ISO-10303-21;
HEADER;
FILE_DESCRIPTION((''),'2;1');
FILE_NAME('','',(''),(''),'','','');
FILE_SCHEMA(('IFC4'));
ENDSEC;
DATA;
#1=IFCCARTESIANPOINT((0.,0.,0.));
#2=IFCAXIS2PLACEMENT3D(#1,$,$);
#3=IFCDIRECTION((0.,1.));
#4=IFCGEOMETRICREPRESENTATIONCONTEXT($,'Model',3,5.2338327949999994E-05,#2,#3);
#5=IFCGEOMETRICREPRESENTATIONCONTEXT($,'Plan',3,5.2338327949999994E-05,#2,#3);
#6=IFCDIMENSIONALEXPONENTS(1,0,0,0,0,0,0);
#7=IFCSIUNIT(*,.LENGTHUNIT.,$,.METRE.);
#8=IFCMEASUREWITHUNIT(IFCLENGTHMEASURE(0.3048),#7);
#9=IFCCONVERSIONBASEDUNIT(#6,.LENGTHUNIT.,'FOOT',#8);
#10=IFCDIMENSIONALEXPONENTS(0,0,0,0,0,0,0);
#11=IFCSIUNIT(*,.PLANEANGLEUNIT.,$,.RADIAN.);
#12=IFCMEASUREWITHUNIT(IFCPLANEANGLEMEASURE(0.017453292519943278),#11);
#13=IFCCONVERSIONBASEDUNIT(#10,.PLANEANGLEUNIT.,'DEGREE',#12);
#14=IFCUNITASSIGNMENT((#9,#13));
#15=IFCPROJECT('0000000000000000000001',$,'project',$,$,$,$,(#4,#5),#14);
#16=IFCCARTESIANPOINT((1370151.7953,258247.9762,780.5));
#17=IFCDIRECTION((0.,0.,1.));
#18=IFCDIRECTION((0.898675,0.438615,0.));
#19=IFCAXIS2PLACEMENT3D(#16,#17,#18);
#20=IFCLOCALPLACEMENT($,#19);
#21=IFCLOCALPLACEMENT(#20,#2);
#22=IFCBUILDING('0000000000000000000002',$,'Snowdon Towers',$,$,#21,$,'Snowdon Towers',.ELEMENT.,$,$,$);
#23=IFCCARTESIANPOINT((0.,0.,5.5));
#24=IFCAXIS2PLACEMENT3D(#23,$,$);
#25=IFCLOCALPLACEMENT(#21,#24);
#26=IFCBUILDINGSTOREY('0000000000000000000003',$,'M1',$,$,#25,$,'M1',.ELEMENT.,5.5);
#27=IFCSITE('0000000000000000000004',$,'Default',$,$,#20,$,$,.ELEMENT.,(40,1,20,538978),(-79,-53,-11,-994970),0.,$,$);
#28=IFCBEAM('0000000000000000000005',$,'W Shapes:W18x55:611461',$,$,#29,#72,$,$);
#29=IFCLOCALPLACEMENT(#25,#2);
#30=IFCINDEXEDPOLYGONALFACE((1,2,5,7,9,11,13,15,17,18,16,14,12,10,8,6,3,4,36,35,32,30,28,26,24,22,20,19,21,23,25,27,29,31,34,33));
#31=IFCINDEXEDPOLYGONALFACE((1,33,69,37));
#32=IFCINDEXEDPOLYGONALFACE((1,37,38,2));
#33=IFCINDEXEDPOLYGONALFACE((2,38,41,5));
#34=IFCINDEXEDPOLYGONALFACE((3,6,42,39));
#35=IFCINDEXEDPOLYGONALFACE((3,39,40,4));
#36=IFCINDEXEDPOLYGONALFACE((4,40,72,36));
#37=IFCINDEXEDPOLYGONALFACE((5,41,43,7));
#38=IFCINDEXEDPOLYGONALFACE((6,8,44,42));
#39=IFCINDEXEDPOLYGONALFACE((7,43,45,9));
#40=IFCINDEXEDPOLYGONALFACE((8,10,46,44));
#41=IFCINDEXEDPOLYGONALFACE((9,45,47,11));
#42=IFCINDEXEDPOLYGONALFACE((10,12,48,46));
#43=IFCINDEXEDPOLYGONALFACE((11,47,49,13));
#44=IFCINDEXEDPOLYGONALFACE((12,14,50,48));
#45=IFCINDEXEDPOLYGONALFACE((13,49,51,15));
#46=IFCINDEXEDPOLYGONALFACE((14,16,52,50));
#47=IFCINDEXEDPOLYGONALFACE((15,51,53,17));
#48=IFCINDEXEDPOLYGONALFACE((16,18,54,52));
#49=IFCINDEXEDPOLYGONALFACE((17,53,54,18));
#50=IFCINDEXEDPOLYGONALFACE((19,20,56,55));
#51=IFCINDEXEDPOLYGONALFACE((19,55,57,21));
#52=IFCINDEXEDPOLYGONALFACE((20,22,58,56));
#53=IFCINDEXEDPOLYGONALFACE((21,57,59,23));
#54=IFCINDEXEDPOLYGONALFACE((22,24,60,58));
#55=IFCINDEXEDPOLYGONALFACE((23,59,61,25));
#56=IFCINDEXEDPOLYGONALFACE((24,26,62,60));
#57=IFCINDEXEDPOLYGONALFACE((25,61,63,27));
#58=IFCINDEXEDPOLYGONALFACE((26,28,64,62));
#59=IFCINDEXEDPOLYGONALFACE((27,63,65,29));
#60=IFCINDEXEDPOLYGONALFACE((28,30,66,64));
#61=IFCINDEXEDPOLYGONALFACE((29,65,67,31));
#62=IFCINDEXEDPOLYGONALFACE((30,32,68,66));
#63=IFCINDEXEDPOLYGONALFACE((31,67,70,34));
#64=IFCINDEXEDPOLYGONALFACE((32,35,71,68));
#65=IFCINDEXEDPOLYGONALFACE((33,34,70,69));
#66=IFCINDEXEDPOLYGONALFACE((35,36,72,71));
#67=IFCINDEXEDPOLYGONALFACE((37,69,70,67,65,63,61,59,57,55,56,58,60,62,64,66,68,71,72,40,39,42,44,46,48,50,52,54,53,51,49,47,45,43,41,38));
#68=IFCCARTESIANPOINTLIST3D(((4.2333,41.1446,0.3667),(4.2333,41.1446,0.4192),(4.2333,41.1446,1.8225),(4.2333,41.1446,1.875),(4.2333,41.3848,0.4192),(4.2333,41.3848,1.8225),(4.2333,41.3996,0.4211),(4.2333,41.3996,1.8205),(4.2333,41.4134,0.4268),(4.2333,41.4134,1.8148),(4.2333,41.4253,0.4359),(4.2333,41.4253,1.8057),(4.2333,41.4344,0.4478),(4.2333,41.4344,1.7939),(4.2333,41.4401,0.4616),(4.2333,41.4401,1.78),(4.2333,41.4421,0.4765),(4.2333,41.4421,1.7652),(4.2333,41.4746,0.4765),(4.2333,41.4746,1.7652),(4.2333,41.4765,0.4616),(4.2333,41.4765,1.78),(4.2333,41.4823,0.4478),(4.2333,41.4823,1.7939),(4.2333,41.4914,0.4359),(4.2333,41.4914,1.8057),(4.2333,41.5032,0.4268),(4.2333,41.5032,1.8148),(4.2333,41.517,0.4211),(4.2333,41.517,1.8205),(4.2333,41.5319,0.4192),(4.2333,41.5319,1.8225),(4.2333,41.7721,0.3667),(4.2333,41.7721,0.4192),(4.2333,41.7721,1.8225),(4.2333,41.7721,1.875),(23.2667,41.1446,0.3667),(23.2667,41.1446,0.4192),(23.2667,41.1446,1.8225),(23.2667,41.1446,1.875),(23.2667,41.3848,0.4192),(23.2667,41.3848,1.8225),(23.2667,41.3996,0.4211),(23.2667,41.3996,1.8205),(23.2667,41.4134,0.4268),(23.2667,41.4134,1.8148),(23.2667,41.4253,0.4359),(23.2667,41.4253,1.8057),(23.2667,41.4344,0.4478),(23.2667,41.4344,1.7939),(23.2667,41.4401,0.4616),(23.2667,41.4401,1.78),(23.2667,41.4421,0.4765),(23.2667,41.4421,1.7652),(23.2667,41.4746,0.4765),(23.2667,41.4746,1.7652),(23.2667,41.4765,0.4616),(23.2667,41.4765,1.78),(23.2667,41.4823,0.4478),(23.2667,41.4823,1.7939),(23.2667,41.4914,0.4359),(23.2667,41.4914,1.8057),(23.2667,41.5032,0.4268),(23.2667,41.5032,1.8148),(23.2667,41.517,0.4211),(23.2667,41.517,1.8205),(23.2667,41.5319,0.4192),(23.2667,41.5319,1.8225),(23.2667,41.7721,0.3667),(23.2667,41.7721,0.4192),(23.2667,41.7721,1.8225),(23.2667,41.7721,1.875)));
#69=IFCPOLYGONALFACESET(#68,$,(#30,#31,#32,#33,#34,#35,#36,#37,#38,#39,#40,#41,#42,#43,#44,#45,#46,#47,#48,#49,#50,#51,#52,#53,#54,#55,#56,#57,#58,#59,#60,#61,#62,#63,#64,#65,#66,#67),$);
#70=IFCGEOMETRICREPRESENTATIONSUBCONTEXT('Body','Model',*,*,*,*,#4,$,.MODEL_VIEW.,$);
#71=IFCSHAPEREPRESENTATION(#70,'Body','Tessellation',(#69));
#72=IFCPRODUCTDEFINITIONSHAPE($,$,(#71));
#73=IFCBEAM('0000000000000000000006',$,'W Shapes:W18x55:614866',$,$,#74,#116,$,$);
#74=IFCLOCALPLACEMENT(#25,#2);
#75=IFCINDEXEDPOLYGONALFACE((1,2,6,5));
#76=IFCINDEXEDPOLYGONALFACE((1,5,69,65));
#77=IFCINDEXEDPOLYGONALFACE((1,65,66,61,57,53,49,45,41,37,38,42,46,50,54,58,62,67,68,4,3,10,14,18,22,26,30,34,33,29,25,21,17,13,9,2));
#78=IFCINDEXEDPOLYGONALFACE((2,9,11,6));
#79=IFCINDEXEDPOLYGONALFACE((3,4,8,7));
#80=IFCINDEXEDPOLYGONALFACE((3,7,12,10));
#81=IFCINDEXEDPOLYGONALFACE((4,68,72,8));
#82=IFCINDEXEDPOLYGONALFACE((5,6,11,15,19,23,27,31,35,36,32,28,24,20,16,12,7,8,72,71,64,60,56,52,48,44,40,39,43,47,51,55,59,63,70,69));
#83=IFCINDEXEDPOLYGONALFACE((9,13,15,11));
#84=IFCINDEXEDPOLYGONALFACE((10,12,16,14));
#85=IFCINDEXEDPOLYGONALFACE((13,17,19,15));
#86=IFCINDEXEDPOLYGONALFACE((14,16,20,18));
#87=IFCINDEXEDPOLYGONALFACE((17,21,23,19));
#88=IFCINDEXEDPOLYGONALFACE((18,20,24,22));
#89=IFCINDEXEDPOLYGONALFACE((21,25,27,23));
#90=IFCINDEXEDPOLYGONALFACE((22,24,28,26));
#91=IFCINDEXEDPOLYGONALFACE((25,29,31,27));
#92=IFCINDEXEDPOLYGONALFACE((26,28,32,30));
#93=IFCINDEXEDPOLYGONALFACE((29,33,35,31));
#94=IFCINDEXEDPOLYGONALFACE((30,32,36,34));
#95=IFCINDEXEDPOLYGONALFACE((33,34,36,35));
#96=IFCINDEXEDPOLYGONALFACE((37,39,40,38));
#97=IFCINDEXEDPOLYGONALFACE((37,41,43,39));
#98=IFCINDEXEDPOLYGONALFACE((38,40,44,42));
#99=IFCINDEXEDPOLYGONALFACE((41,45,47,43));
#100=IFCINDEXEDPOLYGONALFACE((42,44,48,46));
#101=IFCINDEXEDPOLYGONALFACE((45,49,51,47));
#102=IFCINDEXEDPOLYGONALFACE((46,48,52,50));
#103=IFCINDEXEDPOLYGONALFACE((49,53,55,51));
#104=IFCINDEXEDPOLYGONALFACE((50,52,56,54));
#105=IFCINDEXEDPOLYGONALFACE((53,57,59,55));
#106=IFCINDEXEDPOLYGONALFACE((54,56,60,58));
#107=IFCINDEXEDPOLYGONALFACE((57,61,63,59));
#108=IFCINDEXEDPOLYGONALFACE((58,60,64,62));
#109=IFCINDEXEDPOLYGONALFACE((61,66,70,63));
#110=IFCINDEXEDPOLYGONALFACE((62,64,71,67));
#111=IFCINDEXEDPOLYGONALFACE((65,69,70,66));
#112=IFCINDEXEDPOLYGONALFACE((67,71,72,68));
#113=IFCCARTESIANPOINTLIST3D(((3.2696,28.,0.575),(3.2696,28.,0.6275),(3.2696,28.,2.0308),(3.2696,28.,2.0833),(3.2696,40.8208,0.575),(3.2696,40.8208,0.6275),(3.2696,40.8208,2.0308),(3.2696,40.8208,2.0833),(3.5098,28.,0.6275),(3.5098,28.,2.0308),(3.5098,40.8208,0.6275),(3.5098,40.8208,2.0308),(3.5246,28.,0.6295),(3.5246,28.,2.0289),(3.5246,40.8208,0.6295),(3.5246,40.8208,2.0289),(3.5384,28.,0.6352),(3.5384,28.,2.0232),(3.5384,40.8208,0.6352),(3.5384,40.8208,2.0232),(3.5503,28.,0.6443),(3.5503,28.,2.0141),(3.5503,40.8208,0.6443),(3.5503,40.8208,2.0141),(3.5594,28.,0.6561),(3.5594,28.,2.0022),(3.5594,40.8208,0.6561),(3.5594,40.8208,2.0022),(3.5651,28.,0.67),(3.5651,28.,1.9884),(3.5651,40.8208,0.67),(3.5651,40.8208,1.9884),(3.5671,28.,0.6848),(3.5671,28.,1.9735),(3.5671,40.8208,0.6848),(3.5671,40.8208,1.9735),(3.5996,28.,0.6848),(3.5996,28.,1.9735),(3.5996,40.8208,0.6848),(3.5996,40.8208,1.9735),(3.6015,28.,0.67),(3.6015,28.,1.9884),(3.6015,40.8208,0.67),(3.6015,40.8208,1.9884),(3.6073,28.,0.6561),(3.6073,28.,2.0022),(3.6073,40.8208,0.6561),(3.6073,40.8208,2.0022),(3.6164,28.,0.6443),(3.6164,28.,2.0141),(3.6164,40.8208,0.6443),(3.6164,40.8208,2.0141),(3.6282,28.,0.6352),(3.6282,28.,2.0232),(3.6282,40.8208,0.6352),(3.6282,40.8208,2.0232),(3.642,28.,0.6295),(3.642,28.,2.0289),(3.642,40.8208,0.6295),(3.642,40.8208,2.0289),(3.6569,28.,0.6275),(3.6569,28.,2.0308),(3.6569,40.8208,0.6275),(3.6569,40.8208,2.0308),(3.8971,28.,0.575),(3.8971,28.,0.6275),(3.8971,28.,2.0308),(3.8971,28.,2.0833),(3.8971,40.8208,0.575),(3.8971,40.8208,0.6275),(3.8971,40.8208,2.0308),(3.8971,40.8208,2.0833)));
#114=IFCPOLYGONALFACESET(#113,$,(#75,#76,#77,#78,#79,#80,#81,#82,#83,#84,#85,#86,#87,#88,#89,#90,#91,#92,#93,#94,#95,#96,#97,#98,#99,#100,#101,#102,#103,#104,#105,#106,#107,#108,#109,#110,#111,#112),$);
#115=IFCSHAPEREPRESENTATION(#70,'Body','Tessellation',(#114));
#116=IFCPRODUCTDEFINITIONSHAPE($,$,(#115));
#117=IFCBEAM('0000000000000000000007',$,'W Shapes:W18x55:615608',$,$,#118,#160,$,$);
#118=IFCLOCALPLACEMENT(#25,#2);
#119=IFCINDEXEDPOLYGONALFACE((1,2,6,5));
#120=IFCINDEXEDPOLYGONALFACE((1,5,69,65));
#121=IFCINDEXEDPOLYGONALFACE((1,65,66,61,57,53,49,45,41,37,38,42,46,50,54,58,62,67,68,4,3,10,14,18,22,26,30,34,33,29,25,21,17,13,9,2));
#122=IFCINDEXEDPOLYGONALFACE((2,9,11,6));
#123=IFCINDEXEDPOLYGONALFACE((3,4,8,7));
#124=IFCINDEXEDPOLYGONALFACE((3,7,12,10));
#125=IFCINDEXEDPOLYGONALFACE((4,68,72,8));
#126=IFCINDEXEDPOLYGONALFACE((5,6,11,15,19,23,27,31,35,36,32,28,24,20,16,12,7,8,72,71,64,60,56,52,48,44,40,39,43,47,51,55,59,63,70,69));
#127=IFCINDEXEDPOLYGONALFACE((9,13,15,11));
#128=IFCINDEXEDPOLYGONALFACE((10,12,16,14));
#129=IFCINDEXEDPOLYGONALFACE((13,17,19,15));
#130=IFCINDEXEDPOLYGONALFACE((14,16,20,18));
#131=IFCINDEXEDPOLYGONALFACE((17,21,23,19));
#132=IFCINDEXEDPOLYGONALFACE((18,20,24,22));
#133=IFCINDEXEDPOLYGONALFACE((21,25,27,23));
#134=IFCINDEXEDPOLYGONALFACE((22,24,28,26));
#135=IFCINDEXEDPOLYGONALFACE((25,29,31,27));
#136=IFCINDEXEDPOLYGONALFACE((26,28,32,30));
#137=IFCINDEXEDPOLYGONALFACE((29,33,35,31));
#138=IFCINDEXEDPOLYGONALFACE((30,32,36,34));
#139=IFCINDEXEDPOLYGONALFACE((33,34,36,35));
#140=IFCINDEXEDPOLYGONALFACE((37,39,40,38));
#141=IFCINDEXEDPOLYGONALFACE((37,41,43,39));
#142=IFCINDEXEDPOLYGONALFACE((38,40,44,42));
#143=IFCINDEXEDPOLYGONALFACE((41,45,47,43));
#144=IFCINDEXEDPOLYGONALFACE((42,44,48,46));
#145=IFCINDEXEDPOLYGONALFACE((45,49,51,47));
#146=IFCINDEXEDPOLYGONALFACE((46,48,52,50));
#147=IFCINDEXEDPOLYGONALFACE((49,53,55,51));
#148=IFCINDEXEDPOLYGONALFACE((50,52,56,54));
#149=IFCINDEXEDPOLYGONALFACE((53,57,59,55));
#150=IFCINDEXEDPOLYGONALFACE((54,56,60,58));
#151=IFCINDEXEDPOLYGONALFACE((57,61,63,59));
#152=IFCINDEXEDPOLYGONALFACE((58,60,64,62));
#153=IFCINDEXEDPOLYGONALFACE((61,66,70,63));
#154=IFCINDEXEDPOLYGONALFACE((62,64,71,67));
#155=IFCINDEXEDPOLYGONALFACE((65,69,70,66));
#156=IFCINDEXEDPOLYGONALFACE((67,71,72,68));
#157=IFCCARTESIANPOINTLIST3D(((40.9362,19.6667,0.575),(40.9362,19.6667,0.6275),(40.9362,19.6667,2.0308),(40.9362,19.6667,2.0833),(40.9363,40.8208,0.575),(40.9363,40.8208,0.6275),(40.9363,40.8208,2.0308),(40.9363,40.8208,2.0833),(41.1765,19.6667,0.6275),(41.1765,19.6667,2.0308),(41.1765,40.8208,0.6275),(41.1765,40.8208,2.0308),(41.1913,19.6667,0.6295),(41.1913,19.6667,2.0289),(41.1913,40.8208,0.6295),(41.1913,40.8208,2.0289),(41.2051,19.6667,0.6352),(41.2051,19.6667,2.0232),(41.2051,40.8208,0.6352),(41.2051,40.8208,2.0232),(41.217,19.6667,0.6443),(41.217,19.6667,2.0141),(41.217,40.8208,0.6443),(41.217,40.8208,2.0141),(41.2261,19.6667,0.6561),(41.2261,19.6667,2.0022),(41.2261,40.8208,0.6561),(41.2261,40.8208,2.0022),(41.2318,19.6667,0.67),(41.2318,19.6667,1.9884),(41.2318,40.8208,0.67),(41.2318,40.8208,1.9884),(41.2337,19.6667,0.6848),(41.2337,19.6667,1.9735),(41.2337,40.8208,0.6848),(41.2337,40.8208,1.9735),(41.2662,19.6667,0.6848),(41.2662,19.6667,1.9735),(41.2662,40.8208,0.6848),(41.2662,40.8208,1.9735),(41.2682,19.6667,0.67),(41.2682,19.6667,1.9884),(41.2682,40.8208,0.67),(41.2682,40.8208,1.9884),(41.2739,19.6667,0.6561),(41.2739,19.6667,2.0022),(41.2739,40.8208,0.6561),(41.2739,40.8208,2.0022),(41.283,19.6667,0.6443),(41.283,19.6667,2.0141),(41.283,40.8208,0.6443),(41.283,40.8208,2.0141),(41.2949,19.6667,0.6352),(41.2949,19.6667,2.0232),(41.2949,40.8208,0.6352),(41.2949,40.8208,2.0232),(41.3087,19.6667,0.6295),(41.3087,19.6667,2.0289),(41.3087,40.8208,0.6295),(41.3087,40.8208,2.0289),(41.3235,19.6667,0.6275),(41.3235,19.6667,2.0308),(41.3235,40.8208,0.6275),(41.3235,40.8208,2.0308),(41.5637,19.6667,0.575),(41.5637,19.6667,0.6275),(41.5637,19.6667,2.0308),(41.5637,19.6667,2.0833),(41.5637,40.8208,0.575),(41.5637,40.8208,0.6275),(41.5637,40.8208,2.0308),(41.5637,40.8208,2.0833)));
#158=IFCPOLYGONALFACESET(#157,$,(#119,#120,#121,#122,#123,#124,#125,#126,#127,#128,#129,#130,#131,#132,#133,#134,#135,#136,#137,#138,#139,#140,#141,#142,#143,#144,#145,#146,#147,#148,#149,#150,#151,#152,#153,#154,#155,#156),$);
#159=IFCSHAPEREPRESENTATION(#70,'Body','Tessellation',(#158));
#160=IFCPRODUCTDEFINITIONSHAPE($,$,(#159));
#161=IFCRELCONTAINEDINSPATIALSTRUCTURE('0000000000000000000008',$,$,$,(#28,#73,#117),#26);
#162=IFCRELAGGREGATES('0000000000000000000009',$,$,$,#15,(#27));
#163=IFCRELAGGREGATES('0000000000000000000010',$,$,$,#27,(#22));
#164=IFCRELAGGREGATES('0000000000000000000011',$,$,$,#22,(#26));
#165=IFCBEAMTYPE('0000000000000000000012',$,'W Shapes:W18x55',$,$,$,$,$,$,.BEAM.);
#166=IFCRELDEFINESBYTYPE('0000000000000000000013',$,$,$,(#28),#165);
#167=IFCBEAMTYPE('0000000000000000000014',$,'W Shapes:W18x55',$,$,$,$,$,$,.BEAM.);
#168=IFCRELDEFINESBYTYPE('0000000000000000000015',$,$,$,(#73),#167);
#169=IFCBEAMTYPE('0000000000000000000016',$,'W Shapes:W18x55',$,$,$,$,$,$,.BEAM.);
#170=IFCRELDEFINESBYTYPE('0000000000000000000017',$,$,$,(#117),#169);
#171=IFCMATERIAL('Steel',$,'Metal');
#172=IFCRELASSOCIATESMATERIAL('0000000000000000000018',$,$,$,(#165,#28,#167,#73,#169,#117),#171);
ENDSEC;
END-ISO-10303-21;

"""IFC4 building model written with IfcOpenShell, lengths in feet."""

from ifc_helpers import new_model, entity, si_unit, converted_unit, direction, frame, origin, place, context, subcontext, project, spatial, line, arc, indexed_curve, outline, extrude, source, transform, mapped, material, type_object, type_shapes, element, save


model = new_model("IFC4")

# Units and contexts
model_context = context("Model", 3, precision=5.2338327949999994e-05, world=origin(), true_north=direction((0.0, 1.0)))
plan_context = context("Plan", 3, precision=5.2338327949999994e-05, world=origin(), true_north=direction((0.0, 1.0)))
body_context = subcontext(model_context, "Body", "Model", "MODEL_VIEW")
ifc_project = project(units=[converted_unit("LENGTHUNIT", "FOOT", entity("IfcLengthMeasure", 0.3048), si_unit("LENGTHUNIT", "METRE"), dimensions=[1, 0, 0, 0, 0, 0, 0]), converted_unit("PLANEANGLEUNIT", "DEGREE", entity("IfcPlaneAngleMeasure", 0.017453292519943278), si_unit("PLANEANGLEUNIT", "RADIAN"), dimensions=[0, 0, 0, 0, 0, 0, 0])], contexts=[model_context, plan_context])

# Site, building, storey
site_placement = place(None, frame((1370151.7953, 258247.9762, 780.5), z_axis=(0.0, 0.0, 1.0), x_axis=(0.898675, 0.438615, 0.0)))
site = spatial("IfcSite", under=ifc_project, at=site_placement, Name="Default", CompositionType="ELEMENT", RefLatitude=(40, 1, 20, 538978), RefLongitude=(-79, -53, -11, -994970), RefElevation=0.0)
building_placement = place(site_placement, origin())
building = spatial("IfcBuilding", under=site, at=building_placement, Name="Snowdon Towers", LongName="Snowdon Towers", CompositionType="ELEMENT")
storey_placement = place(building_placement, frame((0.0, 0.0, 5.5)))
storey = spatial("IfcBuildingStorey", under=building, at=storey_placement, Name="M1", LongName="M1", CompositionType="ELEMENT", Elevation=5.5)

# Beams
ifc_material_1 = material(Name="Steel", Category="Metal")
beam_type_1 = type_object("IfcBeamType", Name="W Shapes:W18x55", PredefinedType="BEAM", material=ifc_material_1)
shared_shape_1 = source(origin(), body_context, "Body", "SweptSolid", [
    extrude(outline(indexed_curve([(-0.7542, -0.3138), (-0.7017, -0.3138), (-0.7017, -0.0735), (-0.6849, -0.033), (-0.6444, -0.0162), (0.6444, -0.0162), (0.6849, -0.033), (0.7017, -0.0735), (0.7017, -0.3138), (0.7542, -0.3138), (0.7542, 0.3138), (0.7017, 0.3138), (0.7017, 0.0735), (0.6849, 0.033), (0.6444, 0.0163), (-0.6444, 0.0163), (-0.6849, 0.033), (-0.7017, 0.0735), (-0.7017, 0.3137), (-0.7542, 0.3137)], segments=[line(1, 2, 3), arc(3, 4, 5), line(5, 6), arc(6, 7, 8), line(8, 9, 10, 11, 12, 13), arc(13, 14, 15), line(15, 16), arc(16, 17, 18), line(18, 19, 20, 1)], self_intersect=False)), frame((-9.6, 0.0, 0.0), z_axis=(1.0, 0.0, 0.0), x_axis=(0.0, 0.0, -1.0)), (0.0, 0.0, 1.0), 19.0333),
])
type_shapes(beam_type_1, [shared_shape_1])
beam_1_placement = place(storey_placement, frame((13.8333, 41.4583, 1.1208)))
element("IfcBeam", 1, at=beam_1_placement, inside=storey, type_object=beam_type_1, material=ifc_material_1, Name="W Shapes:W18x55:611461", context=body_context, shape_type="MappedRepresentation", body=[
    mapped(shared_shape_1, transform((0.0, 0.0, 0.0), scale=1.0)),
])
beam_type_2 = type_object("IfcBeamType", Name="W Shapes:W18x55", PredefinedType="BEAM", material=ifc_material_1)
shared_shape_2 = source(origin(), body_context, "Body", "SweptSolid", [
    extrude(outline(indexed_curve([(-0.7542, -0.3138), (-0.7017, -0.3138), (-0.7017, -0.0735), (-0.6849, -0.033), (-0.6444, -0.0162), (0.6444, -0.0162), (0.6849, -0.033), (0.7017, -0.0735), (0.7017, -0.3138), (0.7542, -0.3138), (0.7542, 0.3138), (0.7017, 0.3138), (0.7017, 0.0735), (0.6849, 0.033), (0.6444, 0.0163), (-0.6444, 0.0163), (-0.6849, 0.033), (-0.7017, 0.0735), (-0.7017, 0.3137), (-0.7542, 0.3137)], segments=[line(1, 2, 3), arc(3, 4, 5), line(5, 6), arc(6, 7, 8), line(8, 9, 10, 11, 12, 13), arc(13, 14, 15), line(15, 16), arc(16, 17, 18), line(18, 19, 20, 1)], self_intersect=False)), frame((-6.5833, 0.0, 0.0), z_axis=(1.0, 0.0, 0.0), x_axis=(0.0, 0.0, -1.0)), (0.0, 0.0, 1.0), 12.8208),
])
type_shapes(beam_type_2, [shared_shape_2])
beam_2_placement = place(storey_placement, frame((3.5833, 34.5833, 1.3292), z_axis=(0.0, 0.0, 1.0), x_axis=(0.0, 1.0, 0.0)))
element("IfcBeam", 2, at=beam_2_placement, inside=storey, type_object=beam_type_2, material=ifc_material_1, Name="W Shapes:W18x55:614866", context=body_context, shape_type="MappedRepresentation", body=[
    mapped(shared_shape_2, transform((0.0, 0.0, 0.0), scale=1.0)),
])
beam_type_3 = type_object("IfcBeamType", Name="W Shapes:W18x55", PredefinedType="BEAM", material=ifc_material_1)
shared_shape_3 = source(origin(), body_context, "Body", "SweptSolid", [
    extrude(outline(indexed_curve([(-0.7542, -0.3138), (-0.7017, -0.3138), (-0.7017, -0.0735), (-0.6849, -0.033), (-0.6444, -0.0162), (0.6444, -0.0162), (0.6849, -0.033), (0.7017, -0.0735), (0.7017, -0.3138), (0.7542, -0.3138), (0.7542, 0.3138), (0.7017, 0.3138), (0.7017, 0.0735), (0.6849, 0.033), (0.6444, 0.0163), (-0.6444, 0.0163), (-0.6849, 0.033), (-0.7017, 0.0735), (-0.7017, 0.3137), (-0.7542, 0.3137)], segments=[line(1, 2, 3), arc(3, 4, 5), line(5, 6), arc(6, 7, 8), line(8, 9, 10, 11, 12, 13), arc(13, 14, 15), line(15, 16), arc(16, 17, 18), line(18, 19, 20, 1)], self_intersect=False)), frame((-10.75, 0.0, 0.0), z_axis=(1.0, 0.0, 0.0), x_axis=(0.0, 0.0, -1.0)), (0.0, 0.0, 1.0), 21.1542),
])
type_shapes(beam_type_3, [shared_shape_3])
beam_3_placement = place(storey_placement, frame((41.25, 30.4167, 1.3292), z_axis=(0.0, 0.0, 1.0), x_axis=(0.0, 1.0, 0.0)))
element("IfcBeam", 3, at=beam_3_placement, inside=storey, type_object=beam_type_3, material=ifc_material_1, Name="W Shapes:W18x55:615608", context=body_context, shape_type="MappedRepresentation", body=[
    mapped(shared_shape_3, transform((0.0, 0.0, 0.0), scale=1.0)),
])

save(model, "model.ifc")
